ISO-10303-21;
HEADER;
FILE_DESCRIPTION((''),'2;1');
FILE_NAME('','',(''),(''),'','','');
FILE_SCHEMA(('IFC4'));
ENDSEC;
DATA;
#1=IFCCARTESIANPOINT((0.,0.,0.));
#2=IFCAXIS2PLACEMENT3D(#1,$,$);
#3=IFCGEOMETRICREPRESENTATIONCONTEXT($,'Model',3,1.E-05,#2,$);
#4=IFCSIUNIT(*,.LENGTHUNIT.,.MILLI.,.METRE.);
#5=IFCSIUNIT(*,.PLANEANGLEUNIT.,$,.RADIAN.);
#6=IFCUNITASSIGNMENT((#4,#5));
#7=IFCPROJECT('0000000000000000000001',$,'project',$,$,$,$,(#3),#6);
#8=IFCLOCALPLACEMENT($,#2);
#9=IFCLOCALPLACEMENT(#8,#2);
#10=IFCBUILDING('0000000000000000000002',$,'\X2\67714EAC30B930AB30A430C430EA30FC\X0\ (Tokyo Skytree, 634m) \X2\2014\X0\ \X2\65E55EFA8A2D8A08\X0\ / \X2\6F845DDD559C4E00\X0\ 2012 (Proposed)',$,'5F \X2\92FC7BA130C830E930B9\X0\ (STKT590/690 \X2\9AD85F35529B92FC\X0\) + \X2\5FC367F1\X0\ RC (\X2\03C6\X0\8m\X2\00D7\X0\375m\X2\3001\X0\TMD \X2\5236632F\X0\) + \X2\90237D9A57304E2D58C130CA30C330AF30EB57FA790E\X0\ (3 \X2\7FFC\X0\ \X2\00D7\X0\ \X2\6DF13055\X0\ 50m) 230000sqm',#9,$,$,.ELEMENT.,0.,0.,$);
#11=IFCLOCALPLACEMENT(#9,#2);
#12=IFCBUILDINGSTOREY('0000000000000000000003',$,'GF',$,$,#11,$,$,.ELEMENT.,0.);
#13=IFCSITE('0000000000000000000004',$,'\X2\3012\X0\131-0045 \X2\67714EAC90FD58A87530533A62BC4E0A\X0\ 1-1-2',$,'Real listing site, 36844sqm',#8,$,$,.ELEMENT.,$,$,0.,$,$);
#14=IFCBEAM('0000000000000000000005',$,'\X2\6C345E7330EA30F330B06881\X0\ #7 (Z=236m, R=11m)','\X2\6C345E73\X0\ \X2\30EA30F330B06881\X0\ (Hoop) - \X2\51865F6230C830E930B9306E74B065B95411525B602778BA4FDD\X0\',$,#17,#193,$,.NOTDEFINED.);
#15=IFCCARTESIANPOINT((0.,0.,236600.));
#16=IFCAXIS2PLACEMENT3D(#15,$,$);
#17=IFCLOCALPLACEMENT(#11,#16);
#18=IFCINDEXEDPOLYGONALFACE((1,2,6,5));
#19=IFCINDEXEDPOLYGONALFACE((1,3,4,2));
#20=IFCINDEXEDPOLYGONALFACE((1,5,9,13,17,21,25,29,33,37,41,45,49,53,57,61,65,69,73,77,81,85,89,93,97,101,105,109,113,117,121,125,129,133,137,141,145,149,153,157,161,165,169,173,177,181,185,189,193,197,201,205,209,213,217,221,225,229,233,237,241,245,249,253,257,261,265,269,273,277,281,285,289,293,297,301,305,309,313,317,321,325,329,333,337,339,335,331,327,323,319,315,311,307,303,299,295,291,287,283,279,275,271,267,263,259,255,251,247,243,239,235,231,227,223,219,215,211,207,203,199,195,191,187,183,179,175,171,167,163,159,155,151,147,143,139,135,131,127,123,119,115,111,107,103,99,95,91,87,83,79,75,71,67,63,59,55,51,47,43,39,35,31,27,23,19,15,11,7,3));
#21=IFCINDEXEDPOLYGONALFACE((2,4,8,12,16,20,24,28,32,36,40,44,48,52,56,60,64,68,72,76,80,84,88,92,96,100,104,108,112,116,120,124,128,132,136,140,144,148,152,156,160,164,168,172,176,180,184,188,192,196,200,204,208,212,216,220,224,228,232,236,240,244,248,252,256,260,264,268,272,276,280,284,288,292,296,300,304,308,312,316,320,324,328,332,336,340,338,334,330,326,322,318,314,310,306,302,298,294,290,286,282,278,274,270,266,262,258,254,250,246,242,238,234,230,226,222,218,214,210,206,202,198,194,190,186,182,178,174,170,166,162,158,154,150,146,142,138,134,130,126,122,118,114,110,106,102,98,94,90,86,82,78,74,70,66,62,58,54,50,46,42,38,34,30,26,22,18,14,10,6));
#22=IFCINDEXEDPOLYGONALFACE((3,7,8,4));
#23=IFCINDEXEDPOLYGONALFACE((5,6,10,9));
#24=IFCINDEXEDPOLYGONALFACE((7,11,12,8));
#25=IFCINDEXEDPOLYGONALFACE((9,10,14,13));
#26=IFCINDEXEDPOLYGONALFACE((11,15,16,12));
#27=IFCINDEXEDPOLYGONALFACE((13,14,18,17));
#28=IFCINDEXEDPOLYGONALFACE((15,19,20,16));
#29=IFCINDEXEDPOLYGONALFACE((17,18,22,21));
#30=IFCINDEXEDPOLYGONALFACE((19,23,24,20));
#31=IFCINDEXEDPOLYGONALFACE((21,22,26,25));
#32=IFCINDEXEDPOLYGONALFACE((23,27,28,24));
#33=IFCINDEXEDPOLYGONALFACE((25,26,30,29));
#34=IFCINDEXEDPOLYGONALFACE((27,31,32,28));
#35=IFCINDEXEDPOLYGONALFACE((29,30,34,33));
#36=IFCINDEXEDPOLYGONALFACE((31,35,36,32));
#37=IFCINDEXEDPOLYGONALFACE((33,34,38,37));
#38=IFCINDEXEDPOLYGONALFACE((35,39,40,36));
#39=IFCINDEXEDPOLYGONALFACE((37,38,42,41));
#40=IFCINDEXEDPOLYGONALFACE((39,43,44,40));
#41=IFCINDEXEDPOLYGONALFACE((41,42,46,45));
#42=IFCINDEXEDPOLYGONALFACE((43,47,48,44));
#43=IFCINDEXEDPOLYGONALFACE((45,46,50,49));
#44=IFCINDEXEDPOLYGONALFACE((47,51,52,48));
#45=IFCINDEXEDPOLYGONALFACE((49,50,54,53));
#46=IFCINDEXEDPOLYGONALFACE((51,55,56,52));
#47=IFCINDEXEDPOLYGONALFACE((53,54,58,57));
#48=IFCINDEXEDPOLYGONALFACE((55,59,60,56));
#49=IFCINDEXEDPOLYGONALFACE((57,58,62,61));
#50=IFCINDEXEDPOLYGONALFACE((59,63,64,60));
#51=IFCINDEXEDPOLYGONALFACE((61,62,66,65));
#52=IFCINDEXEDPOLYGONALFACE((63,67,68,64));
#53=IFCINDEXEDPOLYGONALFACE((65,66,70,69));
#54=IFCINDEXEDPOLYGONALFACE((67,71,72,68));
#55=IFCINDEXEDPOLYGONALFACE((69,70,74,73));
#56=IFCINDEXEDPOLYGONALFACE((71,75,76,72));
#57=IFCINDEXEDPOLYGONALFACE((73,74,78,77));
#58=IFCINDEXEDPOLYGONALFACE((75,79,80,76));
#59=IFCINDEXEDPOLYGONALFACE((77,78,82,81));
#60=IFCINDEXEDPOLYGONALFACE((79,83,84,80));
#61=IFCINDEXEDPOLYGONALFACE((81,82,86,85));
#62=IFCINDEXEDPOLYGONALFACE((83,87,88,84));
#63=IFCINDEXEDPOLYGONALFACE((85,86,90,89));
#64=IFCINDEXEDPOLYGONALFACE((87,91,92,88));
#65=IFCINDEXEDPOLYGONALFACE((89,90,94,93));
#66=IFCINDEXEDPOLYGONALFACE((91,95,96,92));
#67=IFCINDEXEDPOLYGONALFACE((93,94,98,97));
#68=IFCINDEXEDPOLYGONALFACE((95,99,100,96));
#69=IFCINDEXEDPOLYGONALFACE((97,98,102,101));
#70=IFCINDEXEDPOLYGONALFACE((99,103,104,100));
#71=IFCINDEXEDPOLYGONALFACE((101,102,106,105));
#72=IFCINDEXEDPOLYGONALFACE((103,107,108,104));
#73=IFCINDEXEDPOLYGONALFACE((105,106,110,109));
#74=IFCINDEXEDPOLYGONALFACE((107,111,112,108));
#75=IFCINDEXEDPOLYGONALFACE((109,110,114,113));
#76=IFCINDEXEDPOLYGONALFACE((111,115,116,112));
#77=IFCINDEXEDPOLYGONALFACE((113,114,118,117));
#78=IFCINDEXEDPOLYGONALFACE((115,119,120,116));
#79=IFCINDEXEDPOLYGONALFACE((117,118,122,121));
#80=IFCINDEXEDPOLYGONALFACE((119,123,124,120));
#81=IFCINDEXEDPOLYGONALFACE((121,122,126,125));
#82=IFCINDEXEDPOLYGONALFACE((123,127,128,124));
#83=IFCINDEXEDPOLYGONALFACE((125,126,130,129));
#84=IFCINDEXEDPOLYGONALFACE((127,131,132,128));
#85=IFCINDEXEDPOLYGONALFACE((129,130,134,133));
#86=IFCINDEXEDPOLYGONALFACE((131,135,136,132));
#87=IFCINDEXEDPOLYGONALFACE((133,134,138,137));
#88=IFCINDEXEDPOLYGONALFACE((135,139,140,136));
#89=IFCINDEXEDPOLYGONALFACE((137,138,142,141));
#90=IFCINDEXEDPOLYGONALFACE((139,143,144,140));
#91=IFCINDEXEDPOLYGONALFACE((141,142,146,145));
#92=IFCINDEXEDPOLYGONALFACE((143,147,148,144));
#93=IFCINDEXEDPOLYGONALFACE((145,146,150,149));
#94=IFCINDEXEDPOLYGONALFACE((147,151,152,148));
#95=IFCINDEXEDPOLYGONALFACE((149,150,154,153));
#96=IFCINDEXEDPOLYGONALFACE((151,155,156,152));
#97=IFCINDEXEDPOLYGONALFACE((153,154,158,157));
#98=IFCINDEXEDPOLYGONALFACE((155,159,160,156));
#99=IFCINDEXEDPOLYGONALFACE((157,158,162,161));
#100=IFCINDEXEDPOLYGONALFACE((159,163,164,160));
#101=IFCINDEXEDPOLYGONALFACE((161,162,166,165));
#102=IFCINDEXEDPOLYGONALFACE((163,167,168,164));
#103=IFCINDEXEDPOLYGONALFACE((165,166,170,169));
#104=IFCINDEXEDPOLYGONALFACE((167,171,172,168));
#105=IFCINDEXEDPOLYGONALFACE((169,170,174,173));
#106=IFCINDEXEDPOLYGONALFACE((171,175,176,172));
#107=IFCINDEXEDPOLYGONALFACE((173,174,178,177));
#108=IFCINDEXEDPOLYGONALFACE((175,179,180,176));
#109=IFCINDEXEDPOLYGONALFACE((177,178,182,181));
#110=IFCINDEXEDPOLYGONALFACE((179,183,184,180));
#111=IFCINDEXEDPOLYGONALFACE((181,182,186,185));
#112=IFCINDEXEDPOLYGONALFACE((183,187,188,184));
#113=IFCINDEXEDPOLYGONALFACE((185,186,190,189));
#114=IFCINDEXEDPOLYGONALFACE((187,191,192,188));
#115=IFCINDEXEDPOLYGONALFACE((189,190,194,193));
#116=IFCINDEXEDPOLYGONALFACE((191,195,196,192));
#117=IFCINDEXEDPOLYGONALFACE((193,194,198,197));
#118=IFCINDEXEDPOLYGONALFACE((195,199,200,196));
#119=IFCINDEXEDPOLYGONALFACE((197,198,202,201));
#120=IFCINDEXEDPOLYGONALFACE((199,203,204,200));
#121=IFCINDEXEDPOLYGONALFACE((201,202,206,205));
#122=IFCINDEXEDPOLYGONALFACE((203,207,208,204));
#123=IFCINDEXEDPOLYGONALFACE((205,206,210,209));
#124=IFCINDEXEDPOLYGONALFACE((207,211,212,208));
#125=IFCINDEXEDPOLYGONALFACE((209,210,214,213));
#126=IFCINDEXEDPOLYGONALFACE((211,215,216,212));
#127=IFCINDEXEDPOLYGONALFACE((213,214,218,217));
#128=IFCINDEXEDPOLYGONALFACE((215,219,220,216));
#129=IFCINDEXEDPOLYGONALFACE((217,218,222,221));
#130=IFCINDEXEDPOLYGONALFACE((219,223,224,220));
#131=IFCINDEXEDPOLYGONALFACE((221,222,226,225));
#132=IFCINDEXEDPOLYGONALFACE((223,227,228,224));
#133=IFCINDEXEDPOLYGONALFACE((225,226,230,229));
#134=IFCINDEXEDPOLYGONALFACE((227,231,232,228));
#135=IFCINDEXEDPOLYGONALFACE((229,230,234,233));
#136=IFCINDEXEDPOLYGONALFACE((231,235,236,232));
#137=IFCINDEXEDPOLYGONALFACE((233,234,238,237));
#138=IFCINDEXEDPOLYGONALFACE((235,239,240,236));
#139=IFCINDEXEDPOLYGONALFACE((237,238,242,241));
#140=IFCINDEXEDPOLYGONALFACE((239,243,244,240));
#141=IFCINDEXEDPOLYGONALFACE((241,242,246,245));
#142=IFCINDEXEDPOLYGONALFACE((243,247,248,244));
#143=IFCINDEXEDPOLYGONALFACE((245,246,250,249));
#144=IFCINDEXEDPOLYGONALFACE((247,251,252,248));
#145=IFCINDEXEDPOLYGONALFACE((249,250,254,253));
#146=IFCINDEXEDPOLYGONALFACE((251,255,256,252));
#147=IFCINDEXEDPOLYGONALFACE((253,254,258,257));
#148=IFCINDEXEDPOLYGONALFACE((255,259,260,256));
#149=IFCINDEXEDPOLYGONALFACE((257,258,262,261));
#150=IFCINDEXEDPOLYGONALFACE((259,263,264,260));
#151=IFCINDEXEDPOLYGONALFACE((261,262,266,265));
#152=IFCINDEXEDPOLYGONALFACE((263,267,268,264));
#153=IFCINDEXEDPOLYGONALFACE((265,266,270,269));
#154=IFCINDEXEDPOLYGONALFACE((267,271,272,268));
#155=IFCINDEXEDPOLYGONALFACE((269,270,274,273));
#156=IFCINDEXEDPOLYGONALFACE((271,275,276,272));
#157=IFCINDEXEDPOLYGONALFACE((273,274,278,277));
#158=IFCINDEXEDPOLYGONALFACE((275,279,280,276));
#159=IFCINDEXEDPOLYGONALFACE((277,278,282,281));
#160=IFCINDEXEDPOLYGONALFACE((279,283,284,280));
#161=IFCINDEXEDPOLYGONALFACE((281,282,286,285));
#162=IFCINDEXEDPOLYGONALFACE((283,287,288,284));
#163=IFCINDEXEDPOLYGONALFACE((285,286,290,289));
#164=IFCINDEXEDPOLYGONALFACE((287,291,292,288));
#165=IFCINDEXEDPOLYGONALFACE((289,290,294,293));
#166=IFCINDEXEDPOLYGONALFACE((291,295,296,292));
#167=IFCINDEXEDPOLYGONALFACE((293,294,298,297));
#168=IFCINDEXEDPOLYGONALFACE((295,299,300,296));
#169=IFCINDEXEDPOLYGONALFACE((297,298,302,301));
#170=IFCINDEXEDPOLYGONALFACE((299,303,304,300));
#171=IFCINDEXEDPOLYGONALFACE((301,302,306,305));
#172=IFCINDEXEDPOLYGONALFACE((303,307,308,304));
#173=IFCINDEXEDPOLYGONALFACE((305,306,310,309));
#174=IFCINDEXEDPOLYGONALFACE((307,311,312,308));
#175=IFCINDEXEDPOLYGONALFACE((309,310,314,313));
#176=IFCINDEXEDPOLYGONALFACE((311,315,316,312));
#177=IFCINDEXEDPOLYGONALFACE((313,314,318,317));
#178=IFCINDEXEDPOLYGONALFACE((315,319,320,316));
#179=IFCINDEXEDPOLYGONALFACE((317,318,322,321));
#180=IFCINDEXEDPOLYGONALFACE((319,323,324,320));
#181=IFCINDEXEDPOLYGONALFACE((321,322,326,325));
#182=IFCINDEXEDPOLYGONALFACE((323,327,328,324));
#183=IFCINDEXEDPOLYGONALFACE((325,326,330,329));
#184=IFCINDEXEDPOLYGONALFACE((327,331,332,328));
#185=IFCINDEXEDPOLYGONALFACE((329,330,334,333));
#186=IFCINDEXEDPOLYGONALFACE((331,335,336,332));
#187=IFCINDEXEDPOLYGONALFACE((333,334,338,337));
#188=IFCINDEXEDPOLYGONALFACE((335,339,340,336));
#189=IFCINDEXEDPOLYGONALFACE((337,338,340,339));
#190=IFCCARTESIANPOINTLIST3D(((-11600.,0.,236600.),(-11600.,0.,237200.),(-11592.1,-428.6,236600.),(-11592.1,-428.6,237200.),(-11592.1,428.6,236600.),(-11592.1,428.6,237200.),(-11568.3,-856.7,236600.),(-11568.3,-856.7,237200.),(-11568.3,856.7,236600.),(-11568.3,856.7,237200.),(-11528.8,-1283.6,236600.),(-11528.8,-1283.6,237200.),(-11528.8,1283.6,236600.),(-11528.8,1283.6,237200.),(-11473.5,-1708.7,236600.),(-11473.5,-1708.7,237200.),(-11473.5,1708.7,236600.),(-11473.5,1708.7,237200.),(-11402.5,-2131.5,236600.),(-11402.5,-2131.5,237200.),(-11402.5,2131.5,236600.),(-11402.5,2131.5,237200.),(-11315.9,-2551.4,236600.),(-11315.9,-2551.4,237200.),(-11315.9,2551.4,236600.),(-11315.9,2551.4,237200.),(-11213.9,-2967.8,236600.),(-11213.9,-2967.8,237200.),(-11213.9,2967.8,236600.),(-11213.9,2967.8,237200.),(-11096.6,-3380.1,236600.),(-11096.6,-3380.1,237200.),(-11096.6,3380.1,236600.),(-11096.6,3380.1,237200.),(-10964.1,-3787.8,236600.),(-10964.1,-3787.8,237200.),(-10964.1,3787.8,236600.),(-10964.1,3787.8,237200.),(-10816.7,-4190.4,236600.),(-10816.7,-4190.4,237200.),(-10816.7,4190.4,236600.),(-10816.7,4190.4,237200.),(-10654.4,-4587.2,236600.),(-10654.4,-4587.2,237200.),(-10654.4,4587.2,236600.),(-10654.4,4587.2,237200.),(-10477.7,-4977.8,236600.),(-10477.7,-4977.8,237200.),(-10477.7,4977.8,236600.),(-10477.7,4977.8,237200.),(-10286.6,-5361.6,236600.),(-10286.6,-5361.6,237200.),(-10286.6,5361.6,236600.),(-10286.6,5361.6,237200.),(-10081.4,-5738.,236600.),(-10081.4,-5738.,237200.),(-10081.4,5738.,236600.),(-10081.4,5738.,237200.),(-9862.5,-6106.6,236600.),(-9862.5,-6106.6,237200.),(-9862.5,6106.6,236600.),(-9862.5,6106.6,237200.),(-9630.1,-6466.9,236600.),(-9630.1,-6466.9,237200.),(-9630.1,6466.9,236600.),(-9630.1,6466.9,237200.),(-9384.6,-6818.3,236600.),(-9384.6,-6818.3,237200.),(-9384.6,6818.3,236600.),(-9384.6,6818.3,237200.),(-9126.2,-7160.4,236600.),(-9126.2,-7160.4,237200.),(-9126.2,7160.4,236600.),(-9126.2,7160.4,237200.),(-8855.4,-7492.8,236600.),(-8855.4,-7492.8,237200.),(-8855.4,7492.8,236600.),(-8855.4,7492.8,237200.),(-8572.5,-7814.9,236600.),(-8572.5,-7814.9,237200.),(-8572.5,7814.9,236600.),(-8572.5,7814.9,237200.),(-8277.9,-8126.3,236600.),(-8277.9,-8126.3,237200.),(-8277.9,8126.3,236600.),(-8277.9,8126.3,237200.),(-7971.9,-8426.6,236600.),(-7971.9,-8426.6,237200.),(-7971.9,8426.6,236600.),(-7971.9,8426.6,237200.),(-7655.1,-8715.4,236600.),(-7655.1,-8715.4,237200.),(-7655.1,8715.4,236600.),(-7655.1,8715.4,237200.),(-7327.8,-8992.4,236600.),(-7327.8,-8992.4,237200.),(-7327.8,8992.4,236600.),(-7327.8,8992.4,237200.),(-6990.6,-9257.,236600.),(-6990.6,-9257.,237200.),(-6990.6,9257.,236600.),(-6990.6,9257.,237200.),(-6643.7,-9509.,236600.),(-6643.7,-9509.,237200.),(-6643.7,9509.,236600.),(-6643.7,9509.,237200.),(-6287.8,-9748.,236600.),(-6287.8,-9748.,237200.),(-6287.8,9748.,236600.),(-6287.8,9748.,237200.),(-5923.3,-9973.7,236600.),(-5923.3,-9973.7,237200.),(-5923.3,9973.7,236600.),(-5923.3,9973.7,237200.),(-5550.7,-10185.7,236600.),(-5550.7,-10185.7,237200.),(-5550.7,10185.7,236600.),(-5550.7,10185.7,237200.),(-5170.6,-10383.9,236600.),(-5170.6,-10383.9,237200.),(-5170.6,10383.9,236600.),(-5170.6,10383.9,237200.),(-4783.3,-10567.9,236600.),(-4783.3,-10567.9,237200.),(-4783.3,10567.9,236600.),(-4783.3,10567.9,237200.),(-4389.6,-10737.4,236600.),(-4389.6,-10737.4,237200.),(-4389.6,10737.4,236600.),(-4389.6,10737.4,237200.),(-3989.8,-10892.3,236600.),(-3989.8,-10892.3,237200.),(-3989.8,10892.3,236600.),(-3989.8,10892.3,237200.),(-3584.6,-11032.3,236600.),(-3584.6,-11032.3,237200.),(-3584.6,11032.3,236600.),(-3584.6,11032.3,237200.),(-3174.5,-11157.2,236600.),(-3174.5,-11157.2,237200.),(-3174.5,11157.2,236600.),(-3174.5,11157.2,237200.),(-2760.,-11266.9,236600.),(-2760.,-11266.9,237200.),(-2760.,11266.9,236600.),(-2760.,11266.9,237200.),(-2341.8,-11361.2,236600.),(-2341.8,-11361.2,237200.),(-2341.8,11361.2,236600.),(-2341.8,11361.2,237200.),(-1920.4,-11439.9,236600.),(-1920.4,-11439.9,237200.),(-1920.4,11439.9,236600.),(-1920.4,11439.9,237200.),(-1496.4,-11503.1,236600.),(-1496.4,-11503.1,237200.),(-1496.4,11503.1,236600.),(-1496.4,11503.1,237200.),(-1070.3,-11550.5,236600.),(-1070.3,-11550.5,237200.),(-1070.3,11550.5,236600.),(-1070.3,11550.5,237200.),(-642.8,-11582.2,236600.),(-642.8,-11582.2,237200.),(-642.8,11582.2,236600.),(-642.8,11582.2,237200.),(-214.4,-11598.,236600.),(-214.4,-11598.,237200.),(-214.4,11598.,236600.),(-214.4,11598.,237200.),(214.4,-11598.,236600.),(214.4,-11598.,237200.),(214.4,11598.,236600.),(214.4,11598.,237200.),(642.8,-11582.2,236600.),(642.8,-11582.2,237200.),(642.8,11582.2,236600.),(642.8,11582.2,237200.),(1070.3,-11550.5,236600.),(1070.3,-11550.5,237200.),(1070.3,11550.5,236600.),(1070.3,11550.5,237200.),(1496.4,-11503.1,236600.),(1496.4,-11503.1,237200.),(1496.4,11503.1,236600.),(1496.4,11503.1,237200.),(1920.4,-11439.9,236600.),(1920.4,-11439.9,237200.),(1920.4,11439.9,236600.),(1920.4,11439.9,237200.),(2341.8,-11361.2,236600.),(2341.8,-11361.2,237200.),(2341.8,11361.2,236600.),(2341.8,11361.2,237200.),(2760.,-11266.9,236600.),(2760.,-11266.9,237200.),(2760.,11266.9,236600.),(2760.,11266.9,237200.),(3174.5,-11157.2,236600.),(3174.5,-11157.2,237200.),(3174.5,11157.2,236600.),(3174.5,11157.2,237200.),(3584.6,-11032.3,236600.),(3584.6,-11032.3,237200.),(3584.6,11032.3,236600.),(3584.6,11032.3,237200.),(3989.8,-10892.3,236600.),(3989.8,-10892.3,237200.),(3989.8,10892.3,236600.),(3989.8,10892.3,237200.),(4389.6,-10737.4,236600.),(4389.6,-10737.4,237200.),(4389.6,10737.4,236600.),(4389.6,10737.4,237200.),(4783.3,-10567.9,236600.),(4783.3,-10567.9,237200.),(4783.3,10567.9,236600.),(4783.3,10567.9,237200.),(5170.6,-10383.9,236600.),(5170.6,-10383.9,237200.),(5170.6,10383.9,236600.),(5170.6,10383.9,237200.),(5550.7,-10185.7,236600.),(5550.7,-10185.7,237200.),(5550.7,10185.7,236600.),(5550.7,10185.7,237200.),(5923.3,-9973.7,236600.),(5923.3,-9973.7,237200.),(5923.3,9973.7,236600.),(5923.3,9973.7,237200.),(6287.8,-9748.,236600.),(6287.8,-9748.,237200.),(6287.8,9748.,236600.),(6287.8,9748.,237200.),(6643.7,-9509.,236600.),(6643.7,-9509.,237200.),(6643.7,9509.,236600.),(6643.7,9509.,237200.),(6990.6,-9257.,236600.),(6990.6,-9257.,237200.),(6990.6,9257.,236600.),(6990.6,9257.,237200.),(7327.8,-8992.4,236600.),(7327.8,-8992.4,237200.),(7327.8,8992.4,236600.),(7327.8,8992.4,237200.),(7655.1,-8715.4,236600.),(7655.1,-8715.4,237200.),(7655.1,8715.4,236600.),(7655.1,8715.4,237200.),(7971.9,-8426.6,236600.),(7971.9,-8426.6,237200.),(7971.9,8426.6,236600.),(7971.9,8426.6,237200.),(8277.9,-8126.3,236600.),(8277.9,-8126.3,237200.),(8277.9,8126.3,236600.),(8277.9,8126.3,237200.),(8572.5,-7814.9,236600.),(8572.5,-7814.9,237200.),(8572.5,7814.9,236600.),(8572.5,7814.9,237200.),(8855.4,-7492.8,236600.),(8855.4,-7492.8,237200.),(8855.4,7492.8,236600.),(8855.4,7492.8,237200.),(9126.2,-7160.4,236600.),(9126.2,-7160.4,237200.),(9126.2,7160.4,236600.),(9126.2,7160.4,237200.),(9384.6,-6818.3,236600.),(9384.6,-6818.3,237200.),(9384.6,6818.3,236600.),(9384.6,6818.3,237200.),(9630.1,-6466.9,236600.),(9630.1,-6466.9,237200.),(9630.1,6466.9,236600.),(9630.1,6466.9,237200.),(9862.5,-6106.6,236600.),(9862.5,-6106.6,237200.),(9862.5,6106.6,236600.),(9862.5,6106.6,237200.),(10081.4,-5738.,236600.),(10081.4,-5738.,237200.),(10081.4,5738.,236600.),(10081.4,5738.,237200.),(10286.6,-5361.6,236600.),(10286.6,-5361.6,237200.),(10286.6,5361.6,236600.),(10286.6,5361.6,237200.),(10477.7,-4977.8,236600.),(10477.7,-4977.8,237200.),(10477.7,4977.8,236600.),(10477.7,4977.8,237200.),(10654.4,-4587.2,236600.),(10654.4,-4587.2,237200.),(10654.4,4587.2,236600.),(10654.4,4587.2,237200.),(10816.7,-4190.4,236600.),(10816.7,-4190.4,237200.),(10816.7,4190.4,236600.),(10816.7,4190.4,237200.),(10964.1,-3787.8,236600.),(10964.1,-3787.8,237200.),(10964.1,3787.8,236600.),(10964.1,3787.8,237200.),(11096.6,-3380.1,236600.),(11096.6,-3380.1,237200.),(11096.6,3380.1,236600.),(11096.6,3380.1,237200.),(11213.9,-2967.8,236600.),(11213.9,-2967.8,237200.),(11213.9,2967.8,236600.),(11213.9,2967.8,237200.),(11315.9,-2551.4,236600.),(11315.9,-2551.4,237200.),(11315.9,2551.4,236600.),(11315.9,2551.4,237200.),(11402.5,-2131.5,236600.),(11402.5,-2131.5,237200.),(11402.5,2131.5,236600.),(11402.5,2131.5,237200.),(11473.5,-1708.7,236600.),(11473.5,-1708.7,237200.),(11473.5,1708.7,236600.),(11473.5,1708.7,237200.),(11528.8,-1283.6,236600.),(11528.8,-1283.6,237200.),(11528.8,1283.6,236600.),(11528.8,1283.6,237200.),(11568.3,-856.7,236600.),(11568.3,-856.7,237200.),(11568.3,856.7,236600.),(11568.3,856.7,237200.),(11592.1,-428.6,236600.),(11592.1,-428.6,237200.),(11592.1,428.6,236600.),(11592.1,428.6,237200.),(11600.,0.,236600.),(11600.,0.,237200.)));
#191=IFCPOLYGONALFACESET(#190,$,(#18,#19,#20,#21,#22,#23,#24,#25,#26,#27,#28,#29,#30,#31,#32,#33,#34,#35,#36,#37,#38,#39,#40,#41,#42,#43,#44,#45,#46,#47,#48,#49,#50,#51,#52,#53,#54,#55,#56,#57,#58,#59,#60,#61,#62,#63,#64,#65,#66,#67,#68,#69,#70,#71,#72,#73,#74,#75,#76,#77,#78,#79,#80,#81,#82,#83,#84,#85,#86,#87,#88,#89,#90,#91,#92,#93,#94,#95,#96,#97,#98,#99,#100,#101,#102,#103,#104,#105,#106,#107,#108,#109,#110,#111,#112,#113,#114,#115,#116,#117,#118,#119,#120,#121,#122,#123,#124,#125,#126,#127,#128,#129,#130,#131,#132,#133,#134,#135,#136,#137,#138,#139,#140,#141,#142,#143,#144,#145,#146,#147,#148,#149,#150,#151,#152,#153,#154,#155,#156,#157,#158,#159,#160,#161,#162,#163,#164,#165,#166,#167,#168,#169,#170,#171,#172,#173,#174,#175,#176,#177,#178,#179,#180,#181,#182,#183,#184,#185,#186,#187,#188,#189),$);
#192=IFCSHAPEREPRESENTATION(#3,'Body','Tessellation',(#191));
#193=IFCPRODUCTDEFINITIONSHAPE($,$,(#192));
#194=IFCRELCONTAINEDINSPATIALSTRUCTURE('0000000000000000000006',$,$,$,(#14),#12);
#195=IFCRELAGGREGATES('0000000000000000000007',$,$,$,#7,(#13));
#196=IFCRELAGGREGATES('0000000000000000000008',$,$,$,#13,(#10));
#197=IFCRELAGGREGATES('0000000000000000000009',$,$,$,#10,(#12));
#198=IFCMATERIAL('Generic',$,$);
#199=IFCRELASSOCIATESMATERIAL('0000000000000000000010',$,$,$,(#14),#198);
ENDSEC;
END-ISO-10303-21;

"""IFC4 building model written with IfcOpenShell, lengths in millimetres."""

from ifc_helpers import new_model, si_unit, frame, origin, origin_2d, place, context, project, spatial, circle, extrude, material, element, save


model = new_model("IFC4")

# Units and contexts
model_context = context("Model", 3, precision=1e-05, world=origin())
ifc_project = project(units=[si_unit("LENGTHUNIT", "METRE", prefix="MILLI"), si_unit("PLANEANGLEUNIT", "RADIAN")], contexts=[model_context])

# Site, building, storey
site_placement = place(None, origin())
site = spatial("IfcSite", under=ifc_project, at=site_placement, Name="〒131-0045 東京都墨田区押上 1-1-2", ObjectType="Real listing site, 36844sqm", CompositionType="ELEMENT", RefElevation=0.0)
building_placement = place(site_placement, origin())
building = spatial("IfcBuilding", under=site, at=building_placement, Name="東京スカイツリー (Tokyo Skytree, 634m) — 日建設計 / 澄川喜一 2012 (Proposed)", ObjectType="5F 鋼管トラス (STKT590/690 高張力鋼) + 心柱 RC (φ8m×375m、TMD 制振) + 連続地中壁ナックル基礎 (3 翼 × 深さ 50m) 230000sqm", CompositionType="ELEMENT", ElevationOfRefHeight=0.0, ElevationOfTerrain=0.0)
storey_placement = place(building_placement, origin())
storey = spatial("IfcBuildingStorey", under=building, at=storey_placement, Name="GF", CompositionType="ELEMENT", Elevation=0.0)

# Shared definitions
ifc_material_1 = material(Name="Generic")

# Beam
beam_1_placement = place(storey_placement, frame((0.0, 0.0, 236600.0)))
element("IfcBeam", 1, at=beam_1_placement, inside=storey, material=ifc_material_1, Name="水平リング梁 #7 (Z=236m, R=11m)", Description="水平 リング梁 (Hoop) - 円形トラスの環方向剛性確保", PredefinedType="NOTDEFINED", context=model_context, shape_type="SweptSolid", body=[
    extrude(circle(Radius=11600.0, at=origin_2d()), frame((0.0, 0.0, 236600.0)), (0.0, 0.0, 1.0), 600.0),
])

save(model, "model.ifc")
